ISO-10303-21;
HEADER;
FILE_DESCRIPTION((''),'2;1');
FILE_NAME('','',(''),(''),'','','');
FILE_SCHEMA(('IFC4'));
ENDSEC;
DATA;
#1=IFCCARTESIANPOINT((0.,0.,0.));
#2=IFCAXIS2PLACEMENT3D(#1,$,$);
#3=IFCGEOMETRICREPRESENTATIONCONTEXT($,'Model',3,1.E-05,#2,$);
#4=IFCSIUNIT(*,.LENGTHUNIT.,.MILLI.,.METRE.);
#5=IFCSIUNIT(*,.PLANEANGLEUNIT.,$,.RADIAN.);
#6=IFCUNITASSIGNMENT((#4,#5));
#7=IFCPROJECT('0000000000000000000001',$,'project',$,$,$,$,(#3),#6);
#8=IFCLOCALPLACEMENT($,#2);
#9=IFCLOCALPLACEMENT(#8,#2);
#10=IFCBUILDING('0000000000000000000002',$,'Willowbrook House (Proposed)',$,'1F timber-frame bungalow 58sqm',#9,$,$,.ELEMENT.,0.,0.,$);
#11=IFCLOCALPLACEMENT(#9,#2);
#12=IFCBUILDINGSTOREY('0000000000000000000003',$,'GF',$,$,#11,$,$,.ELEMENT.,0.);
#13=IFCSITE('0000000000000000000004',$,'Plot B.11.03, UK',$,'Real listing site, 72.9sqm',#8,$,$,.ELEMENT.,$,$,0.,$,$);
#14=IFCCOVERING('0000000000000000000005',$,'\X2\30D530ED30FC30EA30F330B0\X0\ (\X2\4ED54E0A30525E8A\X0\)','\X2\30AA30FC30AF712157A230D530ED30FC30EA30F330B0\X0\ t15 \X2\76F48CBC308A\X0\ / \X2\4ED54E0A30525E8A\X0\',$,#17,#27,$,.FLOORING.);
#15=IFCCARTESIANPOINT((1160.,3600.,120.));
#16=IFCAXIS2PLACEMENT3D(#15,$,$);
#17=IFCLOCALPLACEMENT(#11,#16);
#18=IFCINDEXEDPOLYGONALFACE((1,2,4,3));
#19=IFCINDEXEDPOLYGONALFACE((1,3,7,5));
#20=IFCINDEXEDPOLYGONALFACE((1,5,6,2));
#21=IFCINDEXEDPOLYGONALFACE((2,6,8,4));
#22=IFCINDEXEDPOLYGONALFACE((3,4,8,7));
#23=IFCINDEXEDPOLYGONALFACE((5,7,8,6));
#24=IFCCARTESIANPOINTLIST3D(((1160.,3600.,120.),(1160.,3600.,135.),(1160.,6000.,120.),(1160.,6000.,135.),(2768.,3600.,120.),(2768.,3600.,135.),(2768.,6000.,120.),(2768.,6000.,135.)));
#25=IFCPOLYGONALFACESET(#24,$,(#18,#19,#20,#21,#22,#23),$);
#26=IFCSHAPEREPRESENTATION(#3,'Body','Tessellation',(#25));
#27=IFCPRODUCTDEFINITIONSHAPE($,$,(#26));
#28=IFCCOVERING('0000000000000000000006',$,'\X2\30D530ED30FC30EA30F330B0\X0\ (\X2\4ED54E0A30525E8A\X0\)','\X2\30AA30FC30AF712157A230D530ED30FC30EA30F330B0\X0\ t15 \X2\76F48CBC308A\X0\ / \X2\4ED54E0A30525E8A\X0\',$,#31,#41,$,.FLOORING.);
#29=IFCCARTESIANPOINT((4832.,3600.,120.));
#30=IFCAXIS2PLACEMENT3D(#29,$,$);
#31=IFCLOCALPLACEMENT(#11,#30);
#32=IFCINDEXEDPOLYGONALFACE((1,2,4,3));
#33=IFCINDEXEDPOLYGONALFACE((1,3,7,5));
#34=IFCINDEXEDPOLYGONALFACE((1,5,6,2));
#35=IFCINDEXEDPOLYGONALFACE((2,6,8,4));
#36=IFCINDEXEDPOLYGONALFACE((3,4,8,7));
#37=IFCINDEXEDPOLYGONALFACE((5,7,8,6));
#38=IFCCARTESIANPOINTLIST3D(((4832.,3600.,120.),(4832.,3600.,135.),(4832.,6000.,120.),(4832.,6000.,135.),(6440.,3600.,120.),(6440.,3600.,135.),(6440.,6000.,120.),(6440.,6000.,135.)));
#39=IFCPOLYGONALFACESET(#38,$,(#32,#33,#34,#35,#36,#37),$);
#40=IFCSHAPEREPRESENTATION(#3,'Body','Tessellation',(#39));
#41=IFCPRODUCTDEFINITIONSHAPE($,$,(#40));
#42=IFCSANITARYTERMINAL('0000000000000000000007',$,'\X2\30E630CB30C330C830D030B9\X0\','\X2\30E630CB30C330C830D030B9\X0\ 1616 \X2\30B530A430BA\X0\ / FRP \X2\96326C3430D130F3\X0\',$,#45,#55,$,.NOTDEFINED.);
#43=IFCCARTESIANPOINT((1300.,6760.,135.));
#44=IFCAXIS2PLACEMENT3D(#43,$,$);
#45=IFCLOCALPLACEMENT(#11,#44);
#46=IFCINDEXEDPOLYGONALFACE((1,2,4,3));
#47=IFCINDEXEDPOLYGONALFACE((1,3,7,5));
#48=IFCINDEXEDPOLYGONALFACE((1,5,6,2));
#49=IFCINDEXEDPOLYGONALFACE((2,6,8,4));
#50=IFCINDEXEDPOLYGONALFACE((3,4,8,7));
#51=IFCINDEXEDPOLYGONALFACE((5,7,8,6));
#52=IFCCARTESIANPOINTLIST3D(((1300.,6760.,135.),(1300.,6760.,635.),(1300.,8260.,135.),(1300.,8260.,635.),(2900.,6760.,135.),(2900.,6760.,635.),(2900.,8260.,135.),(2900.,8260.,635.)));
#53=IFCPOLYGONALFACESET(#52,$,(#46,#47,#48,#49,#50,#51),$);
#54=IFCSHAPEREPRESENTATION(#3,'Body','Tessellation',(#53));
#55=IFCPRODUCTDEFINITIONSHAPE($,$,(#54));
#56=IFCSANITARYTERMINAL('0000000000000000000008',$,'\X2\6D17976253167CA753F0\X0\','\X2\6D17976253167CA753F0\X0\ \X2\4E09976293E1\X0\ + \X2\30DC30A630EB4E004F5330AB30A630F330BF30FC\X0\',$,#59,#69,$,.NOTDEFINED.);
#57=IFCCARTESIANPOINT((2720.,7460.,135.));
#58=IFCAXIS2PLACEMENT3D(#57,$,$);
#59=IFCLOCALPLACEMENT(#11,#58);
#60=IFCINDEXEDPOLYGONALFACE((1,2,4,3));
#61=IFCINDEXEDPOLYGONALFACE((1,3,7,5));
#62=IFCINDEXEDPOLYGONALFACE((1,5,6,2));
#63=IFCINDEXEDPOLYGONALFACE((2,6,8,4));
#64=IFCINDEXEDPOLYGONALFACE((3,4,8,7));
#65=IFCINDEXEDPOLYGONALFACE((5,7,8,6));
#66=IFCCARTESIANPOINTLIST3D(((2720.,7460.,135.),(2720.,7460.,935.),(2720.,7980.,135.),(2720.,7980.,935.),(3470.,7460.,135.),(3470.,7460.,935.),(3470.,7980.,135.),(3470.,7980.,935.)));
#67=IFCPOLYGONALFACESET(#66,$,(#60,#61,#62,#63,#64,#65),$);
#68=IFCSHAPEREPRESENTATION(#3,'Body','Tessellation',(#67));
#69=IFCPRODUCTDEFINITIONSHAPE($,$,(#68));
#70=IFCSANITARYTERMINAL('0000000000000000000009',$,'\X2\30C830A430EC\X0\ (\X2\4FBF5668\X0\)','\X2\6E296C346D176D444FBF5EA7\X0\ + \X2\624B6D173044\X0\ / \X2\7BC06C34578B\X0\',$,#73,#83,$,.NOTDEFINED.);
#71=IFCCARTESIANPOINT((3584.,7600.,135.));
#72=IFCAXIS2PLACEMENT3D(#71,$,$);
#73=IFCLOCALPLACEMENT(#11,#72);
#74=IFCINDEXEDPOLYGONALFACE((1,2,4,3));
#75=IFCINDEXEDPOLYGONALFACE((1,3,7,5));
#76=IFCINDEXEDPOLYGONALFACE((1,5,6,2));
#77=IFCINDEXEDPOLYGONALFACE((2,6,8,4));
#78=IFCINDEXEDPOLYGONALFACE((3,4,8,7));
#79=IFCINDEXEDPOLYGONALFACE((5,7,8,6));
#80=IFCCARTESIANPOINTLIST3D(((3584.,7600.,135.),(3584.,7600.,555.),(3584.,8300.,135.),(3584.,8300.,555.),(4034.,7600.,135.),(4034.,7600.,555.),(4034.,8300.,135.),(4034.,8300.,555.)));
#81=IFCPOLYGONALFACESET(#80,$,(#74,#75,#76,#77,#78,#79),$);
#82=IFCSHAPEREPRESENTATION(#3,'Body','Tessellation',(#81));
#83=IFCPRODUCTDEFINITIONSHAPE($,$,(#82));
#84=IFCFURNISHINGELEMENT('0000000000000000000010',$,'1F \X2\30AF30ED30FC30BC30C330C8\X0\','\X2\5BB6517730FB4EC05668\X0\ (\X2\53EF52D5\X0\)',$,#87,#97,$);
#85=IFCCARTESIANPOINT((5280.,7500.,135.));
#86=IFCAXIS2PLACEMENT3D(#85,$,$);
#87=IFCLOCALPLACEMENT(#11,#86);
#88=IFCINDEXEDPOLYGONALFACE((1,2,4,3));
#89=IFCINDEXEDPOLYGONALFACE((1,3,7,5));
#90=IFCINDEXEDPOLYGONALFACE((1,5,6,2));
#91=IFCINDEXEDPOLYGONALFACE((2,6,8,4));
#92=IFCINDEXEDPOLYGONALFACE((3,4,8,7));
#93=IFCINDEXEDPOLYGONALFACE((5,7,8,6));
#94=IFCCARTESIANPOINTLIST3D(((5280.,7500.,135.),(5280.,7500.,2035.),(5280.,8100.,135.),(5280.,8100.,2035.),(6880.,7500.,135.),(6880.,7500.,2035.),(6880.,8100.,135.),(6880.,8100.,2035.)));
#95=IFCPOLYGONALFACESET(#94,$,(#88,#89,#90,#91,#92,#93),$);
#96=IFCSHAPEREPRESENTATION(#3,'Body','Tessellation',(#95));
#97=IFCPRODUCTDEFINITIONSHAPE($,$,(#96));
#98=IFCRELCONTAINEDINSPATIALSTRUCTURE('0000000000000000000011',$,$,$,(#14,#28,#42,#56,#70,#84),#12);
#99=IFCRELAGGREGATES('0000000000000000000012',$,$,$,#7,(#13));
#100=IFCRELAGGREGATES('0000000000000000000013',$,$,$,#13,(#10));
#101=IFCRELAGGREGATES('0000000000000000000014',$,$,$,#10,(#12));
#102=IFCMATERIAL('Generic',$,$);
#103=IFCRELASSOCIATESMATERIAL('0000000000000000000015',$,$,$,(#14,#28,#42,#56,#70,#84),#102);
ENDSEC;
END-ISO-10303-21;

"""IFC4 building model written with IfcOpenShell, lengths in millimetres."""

from ifc_helpers import new_model, si_unit, frame, frame_2d, origin, place, context, project, spatial, rectangle, extrude, material, element, save


model = new_model("IFC4")

# Units and contexts
model_context = context("Model", 3, precision=1e-05, world=origin())
ifc_project = project(units=[si_unit("LENGTHUNIT", "METRE", prefix="MILLI"), si_unit("PLANEANGLEUNIT", "RADIAN")], contexts=[model_context])

# Site, building, storey
site_placement = place(None, origin())
site = spatial("IfcSite", under=ifc_project, at=site_placement, Name="Plot B.11.03, UK", ObjectType="Real listing site, 72.9sqm", CompositionType="ELEMENT", RefElevation=0.0)
building_placement = place(site_placement, origin())
building = spatial("IfcBuilding", under=site, at=building_placement, Name="Willowbrook House (Proposed)", ObjectType="1F timber-frame bungalow 58sqm", CompositionType="ELEMENT", ElevationOfRefHeight=0.0, ElevationOfTerrain=0.0)
storey_placement = place(building_placement, origin())
storey = spatial("IfcBuildingStorey", under=building, at=storey_placement, Name="GF", CompositionType="ELEMENT", Elevation=0.0)

# Coverings
ifc_material_1 = material(Name="Generic")
covering_1_placement = place(storey_placement, frame((1160.0, 3600.0, 120.0)))
element("IfcCovering", 1, at=covering_1_placement, inside=storey, material=ifc_material_1, Name="フローリング (仕上げ床)", Description="オーク無垢フローリング t15 直貼り / 仕上げ床", PredefinedType="FLOORING", context=model_context, shape_type="SweptSolid", body=[
    extrude(rectangle(XDim=1608.0, YDim=2400.0, at=frame_2d((804.0, 1200.0))), frame((1160.0, 3600.0, 120.0)), (0.0, 0.0, 1.0), 15.0),
])
covering_2_placement = place(storey_placement, frame((4832.0, 3600.0, 120.0)))
element("IfcCovering", 2, at=covering_2_placement, inside=storey, material=ifc_material_1, Name="フローリング (仕上げ床)", Description="オーク無垢フローリング t15 直貼り / 仕上げ床", PredefinedType="FLOORING", context=model_context, shape_type="SweptSolid", body=[
    extrude(rectangle(XDim=1608.0, YDim=2400.0, at=frame_2d((804.0, 1200.0))), frame((4832.0, 3600.0, 120.0)), (0.0, 0.0, 1.0), 15.0),
])

# Sanitary terminals
sanitary_terminal_1_placement = place(storey_placement, frame((1300.0, 6760.0, 135.0)))
element("IfcSanitaryTerminal", 3, at=sanitary_terminal_1_placement, inside=storey, material=ifc_material_1, Name="ユニットバス", Description="ユニットバス 1616 サイズ / FRP 防水パン", PredefinedType="NOTDEFINED", context=model_context, shape_type="SweptSolid", body=[
    extrude(rectangle(XDim=1600.0, YDim=1500.0, at=frame_2d((800.0, 750.0))), frame((1300.0, 6760.0, 135.0)), (0.0, 0.0, 1.0), 500.0),
])
sanitary_terminal_2_placement = place(storey_placement, frame((2720.0, 7460.0, 135.0)))
element("IfcSanitaryTerminal", 4, at=sanitary_terminal_2_placement, inside=storey, material=ifc_material_1, Name="洗面化粧台", Description="洗面化粧台 三面鏡 + ボウル一体カウンター", PredefinedType="NOTDEFINED", context=model_context, shape_type="SweptSolid", body=[
    extrude(rectangle(XDim=750.0, YDim=520.0, at=frame_2d((375.0, 260.0))), frame((2720.0, 7460.0, 135.0)), (0.0, 0.0, 1.0), 800.0),
])
sanitary_terminal_3_placement = place(storey_placement, frame((3584.0, 7600.0, 135.0)))
element("IfcSanitaryTerminal", 5, at=sanitary_terminal_3_placement, inside=storey, material=ifc_material_1, Name="トイレ (便器)", Description="温水洗浄便座 + 手洗い / 節水型", PredefinedType="NOTDEFINED", context=model_context, shape_type="SweptSolid", body=[
    extrude(rectangle(XDim=450.0, YDim=700.0, at=frame_2d((225.0, 350.0))), frame((3584.0, 7600.0, 135.0)), (0.0, 0.0, 1.0), 420.0),
])

# Furnishing element
furnishing_placement = place(storey_placement, frame((5280.0, 7500.0, 135.0)))
element("IfcFurnishingElement", 6, at=furnishing_placement, inside=storey, material=ifc_material_1, Name="1F クローゼット", Description="家具・什器 (可動)", context=model_context, shape_type="SweptSolid", body=[
    extrude(rectangle(XDim=1600.0, YDim=600.0, at=frame_2d((800.0, 300.0))), frame((5280.0, 7500.0, 135.0)), (0.0, 0.0, 1.0), 1900.0),
])

save(model, "model.ifc")
